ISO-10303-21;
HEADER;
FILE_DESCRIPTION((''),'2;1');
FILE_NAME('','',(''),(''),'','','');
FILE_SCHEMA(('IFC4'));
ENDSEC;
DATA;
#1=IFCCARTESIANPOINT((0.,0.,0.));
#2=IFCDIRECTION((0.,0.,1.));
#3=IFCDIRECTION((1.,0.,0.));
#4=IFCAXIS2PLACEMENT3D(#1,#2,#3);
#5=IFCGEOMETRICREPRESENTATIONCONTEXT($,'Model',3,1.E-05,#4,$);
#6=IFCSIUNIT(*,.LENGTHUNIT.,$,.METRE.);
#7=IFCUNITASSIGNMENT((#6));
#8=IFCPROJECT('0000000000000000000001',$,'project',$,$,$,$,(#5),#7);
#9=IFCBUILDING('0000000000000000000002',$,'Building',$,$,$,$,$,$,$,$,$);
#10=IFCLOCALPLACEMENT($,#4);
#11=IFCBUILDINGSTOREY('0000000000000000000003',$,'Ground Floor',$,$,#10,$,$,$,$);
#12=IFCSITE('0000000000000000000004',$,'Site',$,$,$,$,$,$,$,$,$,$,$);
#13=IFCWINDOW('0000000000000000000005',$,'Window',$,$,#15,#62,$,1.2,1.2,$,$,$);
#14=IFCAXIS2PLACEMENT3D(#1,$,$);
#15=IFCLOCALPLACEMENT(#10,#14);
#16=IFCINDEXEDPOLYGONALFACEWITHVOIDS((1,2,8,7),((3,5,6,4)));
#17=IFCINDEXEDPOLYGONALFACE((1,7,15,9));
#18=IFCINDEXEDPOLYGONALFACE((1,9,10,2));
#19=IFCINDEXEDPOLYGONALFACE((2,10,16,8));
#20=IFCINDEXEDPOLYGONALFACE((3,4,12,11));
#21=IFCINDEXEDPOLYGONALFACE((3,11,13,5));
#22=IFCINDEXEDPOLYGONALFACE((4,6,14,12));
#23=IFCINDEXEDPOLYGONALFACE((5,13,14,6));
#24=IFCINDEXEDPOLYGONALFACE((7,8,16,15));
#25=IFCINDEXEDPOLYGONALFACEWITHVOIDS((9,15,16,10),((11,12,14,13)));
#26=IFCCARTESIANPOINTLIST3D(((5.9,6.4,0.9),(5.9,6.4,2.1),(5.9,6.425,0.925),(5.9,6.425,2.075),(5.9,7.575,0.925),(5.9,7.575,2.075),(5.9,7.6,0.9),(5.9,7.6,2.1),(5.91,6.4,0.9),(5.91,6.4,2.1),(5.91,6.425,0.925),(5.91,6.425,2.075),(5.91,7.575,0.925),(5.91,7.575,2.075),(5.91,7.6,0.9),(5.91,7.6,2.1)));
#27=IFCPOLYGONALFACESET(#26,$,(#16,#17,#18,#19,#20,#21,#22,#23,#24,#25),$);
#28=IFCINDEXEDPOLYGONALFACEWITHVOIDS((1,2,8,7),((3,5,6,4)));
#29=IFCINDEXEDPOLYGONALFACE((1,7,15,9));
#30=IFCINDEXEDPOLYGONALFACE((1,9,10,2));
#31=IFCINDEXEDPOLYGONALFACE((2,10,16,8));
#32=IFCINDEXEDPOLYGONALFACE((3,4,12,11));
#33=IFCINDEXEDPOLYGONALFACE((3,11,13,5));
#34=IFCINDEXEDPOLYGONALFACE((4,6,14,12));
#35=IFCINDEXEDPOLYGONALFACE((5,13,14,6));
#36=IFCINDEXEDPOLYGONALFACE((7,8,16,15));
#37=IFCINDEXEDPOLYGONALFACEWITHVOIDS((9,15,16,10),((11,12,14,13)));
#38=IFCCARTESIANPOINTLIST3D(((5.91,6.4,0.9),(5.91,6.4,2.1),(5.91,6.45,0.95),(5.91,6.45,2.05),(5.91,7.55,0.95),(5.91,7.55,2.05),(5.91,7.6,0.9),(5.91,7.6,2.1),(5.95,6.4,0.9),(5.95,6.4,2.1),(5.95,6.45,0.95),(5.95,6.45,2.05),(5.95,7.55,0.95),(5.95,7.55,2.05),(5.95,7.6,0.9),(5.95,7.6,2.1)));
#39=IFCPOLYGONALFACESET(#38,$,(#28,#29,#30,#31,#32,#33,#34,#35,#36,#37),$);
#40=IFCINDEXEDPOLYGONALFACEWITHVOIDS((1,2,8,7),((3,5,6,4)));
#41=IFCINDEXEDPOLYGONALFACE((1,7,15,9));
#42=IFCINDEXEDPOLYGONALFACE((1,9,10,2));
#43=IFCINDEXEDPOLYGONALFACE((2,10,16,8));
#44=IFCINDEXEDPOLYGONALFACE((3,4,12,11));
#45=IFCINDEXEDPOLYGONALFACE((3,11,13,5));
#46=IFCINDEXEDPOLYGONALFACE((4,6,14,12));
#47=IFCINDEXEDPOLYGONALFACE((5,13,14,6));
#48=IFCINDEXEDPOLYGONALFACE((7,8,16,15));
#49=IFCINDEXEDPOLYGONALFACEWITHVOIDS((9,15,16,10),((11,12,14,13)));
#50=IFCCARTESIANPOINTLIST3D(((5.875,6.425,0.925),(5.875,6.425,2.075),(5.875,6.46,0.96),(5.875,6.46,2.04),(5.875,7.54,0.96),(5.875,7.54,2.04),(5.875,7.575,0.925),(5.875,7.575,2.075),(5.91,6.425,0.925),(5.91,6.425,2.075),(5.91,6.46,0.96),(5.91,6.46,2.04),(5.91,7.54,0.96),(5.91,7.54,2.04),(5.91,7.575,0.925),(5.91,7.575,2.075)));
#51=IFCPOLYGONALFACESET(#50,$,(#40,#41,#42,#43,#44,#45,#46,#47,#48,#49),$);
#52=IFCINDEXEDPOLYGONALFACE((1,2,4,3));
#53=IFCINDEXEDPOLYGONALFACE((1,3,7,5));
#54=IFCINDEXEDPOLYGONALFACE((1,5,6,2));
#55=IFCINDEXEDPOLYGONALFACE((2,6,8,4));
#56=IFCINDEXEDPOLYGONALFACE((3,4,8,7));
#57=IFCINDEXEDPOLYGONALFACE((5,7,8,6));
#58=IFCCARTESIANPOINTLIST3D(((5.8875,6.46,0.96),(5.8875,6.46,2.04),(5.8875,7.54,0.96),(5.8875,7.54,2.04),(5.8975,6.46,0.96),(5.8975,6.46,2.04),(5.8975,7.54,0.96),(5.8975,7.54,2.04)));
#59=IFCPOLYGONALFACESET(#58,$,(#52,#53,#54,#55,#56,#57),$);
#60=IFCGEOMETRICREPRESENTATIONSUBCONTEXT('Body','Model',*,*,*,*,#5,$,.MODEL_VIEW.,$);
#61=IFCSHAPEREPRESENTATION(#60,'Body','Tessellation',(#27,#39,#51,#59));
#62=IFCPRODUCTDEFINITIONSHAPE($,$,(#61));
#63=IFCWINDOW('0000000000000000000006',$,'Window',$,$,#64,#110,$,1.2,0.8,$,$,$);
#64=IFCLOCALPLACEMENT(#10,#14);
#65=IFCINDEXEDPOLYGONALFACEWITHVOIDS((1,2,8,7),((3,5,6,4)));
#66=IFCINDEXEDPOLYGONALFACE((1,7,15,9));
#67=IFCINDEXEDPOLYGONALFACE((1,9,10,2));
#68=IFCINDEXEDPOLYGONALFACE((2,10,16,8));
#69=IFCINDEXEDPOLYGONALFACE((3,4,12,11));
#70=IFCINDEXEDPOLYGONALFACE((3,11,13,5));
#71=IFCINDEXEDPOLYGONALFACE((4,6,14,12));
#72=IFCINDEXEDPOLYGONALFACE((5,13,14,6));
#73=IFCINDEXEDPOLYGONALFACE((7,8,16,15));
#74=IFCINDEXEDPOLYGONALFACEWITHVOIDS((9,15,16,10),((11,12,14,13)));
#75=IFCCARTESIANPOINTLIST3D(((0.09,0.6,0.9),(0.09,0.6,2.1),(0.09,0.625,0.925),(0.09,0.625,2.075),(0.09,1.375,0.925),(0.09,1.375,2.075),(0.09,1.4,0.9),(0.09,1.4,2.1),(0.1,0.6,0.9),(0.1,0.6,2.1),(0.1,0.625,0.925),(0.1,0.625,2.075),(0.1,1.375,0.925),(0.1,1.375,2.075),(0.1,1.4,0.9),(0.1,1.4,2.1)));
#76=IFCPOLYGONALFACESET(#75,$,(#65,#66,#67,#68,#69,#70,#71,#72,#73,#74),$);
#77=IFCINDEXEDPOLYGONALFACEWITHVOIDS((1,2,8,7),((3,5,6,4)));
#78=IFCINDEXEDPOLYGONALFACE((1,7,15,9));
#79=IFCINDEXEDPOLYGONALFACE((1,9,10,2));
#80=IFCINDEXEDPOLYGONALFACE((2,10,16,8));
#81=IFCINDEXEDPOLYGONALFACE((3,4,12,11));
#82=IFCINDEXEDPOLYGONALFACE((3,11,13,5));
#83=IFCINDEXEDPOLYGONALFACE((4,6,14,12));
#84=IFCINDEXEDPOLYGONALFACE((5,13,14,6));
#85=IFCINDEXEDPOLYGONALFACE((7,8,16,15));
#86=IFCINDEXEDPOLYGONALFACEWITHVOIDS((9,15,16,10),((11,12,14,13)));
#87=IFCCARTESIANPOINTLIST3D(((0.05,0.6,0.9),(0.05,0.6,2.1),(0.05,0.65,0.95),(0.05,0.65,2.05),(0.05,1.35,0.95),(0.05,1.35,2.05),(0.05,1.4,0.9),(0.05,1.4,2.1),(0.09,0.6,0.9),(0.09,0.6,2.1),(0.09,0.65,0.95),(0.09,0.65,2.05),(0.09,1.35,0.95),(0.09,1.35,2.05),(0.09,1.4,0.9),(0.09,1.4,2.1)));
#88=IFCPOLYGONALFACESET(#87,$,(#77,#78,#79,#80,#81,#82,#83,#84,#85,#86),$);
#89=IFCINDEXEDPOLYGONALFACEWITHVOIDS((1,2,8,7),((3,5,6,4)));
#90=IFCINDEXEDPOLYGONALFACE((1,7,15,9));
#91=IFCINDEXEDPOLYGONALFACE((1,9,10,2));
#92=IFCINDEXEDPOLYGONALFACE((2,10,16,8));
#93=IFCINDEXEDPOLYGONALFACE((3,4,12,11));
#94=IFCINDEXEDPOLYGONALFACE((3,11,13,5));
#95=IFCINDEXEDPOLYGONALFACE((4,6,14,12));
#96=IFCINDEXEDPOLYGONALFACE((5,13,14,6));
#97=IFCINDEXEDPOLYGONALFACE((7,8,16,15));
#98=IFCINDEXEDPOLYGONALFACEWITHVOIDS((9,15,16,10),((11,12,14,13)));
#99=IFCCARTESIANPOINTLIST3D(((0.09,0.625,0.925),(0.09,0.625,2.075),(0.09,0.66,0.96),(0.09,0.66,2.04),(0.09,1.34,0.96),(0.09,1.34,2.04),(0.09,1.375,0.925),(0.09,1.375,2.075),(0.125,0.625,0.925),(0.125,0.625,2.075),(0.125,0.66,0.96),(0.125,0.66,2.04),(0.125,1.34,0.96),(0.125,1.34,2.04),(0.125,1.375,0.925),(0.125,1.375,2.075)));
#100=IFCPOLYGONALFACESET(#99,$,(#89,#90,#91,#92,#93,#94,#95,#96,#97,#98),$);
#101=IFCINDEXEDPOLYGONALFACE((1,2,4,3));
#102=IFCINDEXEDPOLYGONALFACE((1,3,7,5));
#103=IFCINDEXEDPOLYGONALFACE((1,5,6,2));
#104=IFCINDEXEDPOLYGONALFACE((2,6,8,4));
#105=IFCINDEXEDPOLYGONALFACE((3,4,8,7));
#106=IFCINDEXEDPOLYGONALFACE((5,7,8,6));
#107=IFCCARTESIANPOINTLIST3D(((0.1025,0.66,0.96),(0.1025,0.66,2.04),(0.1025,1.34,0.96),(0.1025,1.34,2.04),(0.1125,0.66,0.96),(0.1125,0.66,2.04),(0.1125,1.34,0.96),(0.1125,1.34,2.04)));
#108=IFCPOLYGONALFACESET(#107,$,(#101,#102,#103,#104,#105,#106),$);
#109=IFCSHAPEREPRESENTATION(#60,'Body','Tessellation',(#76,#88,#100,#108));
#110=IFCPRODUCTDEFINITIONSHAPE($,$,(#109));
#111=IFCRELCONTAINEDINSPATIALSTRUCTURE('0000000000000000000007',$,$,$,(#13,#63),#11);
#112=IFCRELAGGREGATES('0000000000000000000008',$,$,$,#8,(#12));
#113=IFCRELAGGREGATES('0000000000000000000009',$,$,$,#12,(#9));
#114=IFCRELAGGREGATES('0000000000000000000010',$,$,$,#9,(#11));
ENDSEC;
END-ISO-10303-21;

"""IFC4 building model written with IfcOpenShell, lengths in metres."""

from ifc_helpers import new_model, si_unit, frame, origin_with_axes, place, context, subcontext, project, spatial, line, indexed_curve, outline, extrude, element, save


model = new_model("IFC4")

# Units and contexts
model_context = context("Model", 3, precision=1e-05, world=origin_with_axes())
body_context = subcontext(model_context, "Body", "Model", "MODEL_VIEW")
ifc_project = project(units=[si_unit("LENGTHUNIT", "METRE")], contexts=[model_context])

# Site, building, storey
site = spatial("IfcSite", under=ifc_project, Name="Site")
building = spatial("IfcBuilding", under=site, Name="Building")
storey_placement = place(None, origin_with_axes())
storey = spatial("IfcBuildingStorey", under=building, at=storey_placement, Name="Ground Floor")

# Windows
window_1_placement = place(storey_placement, frame((6.0, 6.4, 0.9), z_axis=(0.0, 0.0, 1.0), x_axis=(0.0, 1.0, 0.0)))
element("IfcWindow", 1, at=window_1_placement, inside=storey, Name="Window", OverallHeight=1.2, OverallWidth=1.2, context=body_context, shape_type="SweptSolid", body=[
    extrude(outline(indexed_curve([(0.0, 0.0), (1.2, 0.0), (1.2, 1.2), (0.0, 1.2)], segments=[line(1, 2, 3, 4, 1)]), holes=[indexed_curve([(0.025, 0.025), (1.175, 0.025), (1.175, 1.175), (0.025, 1.175)], segments=[line(1, 2, 3, 4, 1)])]), frame((0.0, 0.09, 0.0), z_axis=(0.0, -1.0, 0.0), x_axis=(1.0, 0.0, 0.0)), (0.0, 0.0, -1.0), 0.01),
    extrude(outline(indexed_curve([(0.0, 0.0), (1.2, 0.0), (1.2, 1.2), (0.0, 1.2)], segments=[line(1, 2, 3, 4, 1)]), holes=[indexed_curve([(0.05, 0.05), (1.15, 0.05), (1.15, 1.15), (0.05, 1.15)], segments=[line(1, 2, 3, 4, 1)])]), frame((0.0, 0.05, 0.0), z_axis=(0.0, -1.0, 0.0), x_axis=(1.0, 0.0, 0.0)), (0.0, 0.0, -1.0), 0.04),
    extrude(outline(indexed_curve([(0.0, 0.0), (1.15, 0.0), (1.15, 1.15), (0.0, 1.15)], segments=[line(1, 2, 3, 4, 1)]), holes=[indexed_curve([(0.035, 0.035), (1.115, 0.035), (1.115, 1.115), (0.035, 1.115)], segments=[line(1, 2, 3, 4, 1)])]), frame((0.025, 0.09, 0.025), z_axis=(0.0, -1.0, 0.0), x_axis=(1.0, 0.0, 0.0)), (0.0, 0.0, -1.0), 0.035),
    extrude(outline(indexed_curve([(0.035, 0.035), (1.115, 0.035), (1.115, 1.115), (0.035, 1.115)], segments=[line(1, 2, 3, 4, 1)])), frame((0.025, 0.1025, 0.025), z_axis=(0.0, -1.0, 0.0), x_axis=(1.0, 0.0, 0.0)), (0.0, 0.0, -1.0), 0.01),
])
window_2_placement = place(storey_placement, frame((0.0, 1.4, 0.9), z_axis=(0.0, 0.0, 1.0), x_axis=(0.0, -1.0, 0.0)))
element("IfcWindow", 2, at=window_2_placement, inside=storey, Name="Window", OverallHeight=1.2, OverallWidth=0.8, context=body_context, shape_type="SweptSolid", body=[
    extrude(outline(indexed_curve([(0.0, 0.0), (0.8, 0.0), (0.8, 1.2), (0.0, 1.2)], segments=[line(1, 2, 3, 4, 1)]), holes=[indexed_curve([(0.025, 0.025), (0.775, 0.025), (0.775, 1.175), (0.025, 1.175)], segments=[line(1, 2, 3, 4, 1)])]), frame((0.0, 0.09, 0.0), z_axis=(0.0, -1.0, 0.0), x_axis=(1.0, 0.0, 0.0)), (0.0, 0.0, -1.0), 0.01),
    extrude(outline(indexed_curve([(0.0, 0.0), (0.8, 0.0), (0.8, 1.2), (0.0, 1.2)], segments=[line(1, 2, 3, 4, 1)]), holes=[indexed_curve([(0.05, 0.05), (0.75, 0.05), (0.75, 1.15), (0.05, 1.15)], segments=[line(1, 2, 3, 4, 1)])]), frame((0.0, 0.05, 0.0), z_axis=(0.0, -1.0, 0.0), x_axis=(1.0, 0.0, 0.0)), (0.0, 0.0, -1.0), 0.04),
    extrude(outline(indexed_curve([(0.0, 0.0), (0.75, 0.0), (0.75, 1.15), (0.0, 1.15)], segments=[line(1, 2, 3, 4, 1)]), holes=[indexed_curve([(0.035, 0.035), (0.715, 0.035), (0.715, 1.115), (0.035, 1.115)], segments=[line(1, 2, 3, 4, 1)])]), frame((0.025, 0.09, 0.025), z_axis=(0.0, -1.0, 0.0), x_axis=(1.0, 0.0, 0.0)), (0.0, 0.0, -1.0), 0.035),
    extrude(outline(indexed_curve([(0.035, 0.035), (0.715, 0.035), (0.715, 1.115), (0.035, 1.115)], segments=[line(1, 2, 3, 4, 1)])), frame((0.025, 0.1025, 0.025), z_axis=(0.0, -1.0, 0.0), x_axis=(1.0, 0.0, 0.0)), (0.0, 0.0, -1.0), 0.01),
])

save(model, "model.ifc")
